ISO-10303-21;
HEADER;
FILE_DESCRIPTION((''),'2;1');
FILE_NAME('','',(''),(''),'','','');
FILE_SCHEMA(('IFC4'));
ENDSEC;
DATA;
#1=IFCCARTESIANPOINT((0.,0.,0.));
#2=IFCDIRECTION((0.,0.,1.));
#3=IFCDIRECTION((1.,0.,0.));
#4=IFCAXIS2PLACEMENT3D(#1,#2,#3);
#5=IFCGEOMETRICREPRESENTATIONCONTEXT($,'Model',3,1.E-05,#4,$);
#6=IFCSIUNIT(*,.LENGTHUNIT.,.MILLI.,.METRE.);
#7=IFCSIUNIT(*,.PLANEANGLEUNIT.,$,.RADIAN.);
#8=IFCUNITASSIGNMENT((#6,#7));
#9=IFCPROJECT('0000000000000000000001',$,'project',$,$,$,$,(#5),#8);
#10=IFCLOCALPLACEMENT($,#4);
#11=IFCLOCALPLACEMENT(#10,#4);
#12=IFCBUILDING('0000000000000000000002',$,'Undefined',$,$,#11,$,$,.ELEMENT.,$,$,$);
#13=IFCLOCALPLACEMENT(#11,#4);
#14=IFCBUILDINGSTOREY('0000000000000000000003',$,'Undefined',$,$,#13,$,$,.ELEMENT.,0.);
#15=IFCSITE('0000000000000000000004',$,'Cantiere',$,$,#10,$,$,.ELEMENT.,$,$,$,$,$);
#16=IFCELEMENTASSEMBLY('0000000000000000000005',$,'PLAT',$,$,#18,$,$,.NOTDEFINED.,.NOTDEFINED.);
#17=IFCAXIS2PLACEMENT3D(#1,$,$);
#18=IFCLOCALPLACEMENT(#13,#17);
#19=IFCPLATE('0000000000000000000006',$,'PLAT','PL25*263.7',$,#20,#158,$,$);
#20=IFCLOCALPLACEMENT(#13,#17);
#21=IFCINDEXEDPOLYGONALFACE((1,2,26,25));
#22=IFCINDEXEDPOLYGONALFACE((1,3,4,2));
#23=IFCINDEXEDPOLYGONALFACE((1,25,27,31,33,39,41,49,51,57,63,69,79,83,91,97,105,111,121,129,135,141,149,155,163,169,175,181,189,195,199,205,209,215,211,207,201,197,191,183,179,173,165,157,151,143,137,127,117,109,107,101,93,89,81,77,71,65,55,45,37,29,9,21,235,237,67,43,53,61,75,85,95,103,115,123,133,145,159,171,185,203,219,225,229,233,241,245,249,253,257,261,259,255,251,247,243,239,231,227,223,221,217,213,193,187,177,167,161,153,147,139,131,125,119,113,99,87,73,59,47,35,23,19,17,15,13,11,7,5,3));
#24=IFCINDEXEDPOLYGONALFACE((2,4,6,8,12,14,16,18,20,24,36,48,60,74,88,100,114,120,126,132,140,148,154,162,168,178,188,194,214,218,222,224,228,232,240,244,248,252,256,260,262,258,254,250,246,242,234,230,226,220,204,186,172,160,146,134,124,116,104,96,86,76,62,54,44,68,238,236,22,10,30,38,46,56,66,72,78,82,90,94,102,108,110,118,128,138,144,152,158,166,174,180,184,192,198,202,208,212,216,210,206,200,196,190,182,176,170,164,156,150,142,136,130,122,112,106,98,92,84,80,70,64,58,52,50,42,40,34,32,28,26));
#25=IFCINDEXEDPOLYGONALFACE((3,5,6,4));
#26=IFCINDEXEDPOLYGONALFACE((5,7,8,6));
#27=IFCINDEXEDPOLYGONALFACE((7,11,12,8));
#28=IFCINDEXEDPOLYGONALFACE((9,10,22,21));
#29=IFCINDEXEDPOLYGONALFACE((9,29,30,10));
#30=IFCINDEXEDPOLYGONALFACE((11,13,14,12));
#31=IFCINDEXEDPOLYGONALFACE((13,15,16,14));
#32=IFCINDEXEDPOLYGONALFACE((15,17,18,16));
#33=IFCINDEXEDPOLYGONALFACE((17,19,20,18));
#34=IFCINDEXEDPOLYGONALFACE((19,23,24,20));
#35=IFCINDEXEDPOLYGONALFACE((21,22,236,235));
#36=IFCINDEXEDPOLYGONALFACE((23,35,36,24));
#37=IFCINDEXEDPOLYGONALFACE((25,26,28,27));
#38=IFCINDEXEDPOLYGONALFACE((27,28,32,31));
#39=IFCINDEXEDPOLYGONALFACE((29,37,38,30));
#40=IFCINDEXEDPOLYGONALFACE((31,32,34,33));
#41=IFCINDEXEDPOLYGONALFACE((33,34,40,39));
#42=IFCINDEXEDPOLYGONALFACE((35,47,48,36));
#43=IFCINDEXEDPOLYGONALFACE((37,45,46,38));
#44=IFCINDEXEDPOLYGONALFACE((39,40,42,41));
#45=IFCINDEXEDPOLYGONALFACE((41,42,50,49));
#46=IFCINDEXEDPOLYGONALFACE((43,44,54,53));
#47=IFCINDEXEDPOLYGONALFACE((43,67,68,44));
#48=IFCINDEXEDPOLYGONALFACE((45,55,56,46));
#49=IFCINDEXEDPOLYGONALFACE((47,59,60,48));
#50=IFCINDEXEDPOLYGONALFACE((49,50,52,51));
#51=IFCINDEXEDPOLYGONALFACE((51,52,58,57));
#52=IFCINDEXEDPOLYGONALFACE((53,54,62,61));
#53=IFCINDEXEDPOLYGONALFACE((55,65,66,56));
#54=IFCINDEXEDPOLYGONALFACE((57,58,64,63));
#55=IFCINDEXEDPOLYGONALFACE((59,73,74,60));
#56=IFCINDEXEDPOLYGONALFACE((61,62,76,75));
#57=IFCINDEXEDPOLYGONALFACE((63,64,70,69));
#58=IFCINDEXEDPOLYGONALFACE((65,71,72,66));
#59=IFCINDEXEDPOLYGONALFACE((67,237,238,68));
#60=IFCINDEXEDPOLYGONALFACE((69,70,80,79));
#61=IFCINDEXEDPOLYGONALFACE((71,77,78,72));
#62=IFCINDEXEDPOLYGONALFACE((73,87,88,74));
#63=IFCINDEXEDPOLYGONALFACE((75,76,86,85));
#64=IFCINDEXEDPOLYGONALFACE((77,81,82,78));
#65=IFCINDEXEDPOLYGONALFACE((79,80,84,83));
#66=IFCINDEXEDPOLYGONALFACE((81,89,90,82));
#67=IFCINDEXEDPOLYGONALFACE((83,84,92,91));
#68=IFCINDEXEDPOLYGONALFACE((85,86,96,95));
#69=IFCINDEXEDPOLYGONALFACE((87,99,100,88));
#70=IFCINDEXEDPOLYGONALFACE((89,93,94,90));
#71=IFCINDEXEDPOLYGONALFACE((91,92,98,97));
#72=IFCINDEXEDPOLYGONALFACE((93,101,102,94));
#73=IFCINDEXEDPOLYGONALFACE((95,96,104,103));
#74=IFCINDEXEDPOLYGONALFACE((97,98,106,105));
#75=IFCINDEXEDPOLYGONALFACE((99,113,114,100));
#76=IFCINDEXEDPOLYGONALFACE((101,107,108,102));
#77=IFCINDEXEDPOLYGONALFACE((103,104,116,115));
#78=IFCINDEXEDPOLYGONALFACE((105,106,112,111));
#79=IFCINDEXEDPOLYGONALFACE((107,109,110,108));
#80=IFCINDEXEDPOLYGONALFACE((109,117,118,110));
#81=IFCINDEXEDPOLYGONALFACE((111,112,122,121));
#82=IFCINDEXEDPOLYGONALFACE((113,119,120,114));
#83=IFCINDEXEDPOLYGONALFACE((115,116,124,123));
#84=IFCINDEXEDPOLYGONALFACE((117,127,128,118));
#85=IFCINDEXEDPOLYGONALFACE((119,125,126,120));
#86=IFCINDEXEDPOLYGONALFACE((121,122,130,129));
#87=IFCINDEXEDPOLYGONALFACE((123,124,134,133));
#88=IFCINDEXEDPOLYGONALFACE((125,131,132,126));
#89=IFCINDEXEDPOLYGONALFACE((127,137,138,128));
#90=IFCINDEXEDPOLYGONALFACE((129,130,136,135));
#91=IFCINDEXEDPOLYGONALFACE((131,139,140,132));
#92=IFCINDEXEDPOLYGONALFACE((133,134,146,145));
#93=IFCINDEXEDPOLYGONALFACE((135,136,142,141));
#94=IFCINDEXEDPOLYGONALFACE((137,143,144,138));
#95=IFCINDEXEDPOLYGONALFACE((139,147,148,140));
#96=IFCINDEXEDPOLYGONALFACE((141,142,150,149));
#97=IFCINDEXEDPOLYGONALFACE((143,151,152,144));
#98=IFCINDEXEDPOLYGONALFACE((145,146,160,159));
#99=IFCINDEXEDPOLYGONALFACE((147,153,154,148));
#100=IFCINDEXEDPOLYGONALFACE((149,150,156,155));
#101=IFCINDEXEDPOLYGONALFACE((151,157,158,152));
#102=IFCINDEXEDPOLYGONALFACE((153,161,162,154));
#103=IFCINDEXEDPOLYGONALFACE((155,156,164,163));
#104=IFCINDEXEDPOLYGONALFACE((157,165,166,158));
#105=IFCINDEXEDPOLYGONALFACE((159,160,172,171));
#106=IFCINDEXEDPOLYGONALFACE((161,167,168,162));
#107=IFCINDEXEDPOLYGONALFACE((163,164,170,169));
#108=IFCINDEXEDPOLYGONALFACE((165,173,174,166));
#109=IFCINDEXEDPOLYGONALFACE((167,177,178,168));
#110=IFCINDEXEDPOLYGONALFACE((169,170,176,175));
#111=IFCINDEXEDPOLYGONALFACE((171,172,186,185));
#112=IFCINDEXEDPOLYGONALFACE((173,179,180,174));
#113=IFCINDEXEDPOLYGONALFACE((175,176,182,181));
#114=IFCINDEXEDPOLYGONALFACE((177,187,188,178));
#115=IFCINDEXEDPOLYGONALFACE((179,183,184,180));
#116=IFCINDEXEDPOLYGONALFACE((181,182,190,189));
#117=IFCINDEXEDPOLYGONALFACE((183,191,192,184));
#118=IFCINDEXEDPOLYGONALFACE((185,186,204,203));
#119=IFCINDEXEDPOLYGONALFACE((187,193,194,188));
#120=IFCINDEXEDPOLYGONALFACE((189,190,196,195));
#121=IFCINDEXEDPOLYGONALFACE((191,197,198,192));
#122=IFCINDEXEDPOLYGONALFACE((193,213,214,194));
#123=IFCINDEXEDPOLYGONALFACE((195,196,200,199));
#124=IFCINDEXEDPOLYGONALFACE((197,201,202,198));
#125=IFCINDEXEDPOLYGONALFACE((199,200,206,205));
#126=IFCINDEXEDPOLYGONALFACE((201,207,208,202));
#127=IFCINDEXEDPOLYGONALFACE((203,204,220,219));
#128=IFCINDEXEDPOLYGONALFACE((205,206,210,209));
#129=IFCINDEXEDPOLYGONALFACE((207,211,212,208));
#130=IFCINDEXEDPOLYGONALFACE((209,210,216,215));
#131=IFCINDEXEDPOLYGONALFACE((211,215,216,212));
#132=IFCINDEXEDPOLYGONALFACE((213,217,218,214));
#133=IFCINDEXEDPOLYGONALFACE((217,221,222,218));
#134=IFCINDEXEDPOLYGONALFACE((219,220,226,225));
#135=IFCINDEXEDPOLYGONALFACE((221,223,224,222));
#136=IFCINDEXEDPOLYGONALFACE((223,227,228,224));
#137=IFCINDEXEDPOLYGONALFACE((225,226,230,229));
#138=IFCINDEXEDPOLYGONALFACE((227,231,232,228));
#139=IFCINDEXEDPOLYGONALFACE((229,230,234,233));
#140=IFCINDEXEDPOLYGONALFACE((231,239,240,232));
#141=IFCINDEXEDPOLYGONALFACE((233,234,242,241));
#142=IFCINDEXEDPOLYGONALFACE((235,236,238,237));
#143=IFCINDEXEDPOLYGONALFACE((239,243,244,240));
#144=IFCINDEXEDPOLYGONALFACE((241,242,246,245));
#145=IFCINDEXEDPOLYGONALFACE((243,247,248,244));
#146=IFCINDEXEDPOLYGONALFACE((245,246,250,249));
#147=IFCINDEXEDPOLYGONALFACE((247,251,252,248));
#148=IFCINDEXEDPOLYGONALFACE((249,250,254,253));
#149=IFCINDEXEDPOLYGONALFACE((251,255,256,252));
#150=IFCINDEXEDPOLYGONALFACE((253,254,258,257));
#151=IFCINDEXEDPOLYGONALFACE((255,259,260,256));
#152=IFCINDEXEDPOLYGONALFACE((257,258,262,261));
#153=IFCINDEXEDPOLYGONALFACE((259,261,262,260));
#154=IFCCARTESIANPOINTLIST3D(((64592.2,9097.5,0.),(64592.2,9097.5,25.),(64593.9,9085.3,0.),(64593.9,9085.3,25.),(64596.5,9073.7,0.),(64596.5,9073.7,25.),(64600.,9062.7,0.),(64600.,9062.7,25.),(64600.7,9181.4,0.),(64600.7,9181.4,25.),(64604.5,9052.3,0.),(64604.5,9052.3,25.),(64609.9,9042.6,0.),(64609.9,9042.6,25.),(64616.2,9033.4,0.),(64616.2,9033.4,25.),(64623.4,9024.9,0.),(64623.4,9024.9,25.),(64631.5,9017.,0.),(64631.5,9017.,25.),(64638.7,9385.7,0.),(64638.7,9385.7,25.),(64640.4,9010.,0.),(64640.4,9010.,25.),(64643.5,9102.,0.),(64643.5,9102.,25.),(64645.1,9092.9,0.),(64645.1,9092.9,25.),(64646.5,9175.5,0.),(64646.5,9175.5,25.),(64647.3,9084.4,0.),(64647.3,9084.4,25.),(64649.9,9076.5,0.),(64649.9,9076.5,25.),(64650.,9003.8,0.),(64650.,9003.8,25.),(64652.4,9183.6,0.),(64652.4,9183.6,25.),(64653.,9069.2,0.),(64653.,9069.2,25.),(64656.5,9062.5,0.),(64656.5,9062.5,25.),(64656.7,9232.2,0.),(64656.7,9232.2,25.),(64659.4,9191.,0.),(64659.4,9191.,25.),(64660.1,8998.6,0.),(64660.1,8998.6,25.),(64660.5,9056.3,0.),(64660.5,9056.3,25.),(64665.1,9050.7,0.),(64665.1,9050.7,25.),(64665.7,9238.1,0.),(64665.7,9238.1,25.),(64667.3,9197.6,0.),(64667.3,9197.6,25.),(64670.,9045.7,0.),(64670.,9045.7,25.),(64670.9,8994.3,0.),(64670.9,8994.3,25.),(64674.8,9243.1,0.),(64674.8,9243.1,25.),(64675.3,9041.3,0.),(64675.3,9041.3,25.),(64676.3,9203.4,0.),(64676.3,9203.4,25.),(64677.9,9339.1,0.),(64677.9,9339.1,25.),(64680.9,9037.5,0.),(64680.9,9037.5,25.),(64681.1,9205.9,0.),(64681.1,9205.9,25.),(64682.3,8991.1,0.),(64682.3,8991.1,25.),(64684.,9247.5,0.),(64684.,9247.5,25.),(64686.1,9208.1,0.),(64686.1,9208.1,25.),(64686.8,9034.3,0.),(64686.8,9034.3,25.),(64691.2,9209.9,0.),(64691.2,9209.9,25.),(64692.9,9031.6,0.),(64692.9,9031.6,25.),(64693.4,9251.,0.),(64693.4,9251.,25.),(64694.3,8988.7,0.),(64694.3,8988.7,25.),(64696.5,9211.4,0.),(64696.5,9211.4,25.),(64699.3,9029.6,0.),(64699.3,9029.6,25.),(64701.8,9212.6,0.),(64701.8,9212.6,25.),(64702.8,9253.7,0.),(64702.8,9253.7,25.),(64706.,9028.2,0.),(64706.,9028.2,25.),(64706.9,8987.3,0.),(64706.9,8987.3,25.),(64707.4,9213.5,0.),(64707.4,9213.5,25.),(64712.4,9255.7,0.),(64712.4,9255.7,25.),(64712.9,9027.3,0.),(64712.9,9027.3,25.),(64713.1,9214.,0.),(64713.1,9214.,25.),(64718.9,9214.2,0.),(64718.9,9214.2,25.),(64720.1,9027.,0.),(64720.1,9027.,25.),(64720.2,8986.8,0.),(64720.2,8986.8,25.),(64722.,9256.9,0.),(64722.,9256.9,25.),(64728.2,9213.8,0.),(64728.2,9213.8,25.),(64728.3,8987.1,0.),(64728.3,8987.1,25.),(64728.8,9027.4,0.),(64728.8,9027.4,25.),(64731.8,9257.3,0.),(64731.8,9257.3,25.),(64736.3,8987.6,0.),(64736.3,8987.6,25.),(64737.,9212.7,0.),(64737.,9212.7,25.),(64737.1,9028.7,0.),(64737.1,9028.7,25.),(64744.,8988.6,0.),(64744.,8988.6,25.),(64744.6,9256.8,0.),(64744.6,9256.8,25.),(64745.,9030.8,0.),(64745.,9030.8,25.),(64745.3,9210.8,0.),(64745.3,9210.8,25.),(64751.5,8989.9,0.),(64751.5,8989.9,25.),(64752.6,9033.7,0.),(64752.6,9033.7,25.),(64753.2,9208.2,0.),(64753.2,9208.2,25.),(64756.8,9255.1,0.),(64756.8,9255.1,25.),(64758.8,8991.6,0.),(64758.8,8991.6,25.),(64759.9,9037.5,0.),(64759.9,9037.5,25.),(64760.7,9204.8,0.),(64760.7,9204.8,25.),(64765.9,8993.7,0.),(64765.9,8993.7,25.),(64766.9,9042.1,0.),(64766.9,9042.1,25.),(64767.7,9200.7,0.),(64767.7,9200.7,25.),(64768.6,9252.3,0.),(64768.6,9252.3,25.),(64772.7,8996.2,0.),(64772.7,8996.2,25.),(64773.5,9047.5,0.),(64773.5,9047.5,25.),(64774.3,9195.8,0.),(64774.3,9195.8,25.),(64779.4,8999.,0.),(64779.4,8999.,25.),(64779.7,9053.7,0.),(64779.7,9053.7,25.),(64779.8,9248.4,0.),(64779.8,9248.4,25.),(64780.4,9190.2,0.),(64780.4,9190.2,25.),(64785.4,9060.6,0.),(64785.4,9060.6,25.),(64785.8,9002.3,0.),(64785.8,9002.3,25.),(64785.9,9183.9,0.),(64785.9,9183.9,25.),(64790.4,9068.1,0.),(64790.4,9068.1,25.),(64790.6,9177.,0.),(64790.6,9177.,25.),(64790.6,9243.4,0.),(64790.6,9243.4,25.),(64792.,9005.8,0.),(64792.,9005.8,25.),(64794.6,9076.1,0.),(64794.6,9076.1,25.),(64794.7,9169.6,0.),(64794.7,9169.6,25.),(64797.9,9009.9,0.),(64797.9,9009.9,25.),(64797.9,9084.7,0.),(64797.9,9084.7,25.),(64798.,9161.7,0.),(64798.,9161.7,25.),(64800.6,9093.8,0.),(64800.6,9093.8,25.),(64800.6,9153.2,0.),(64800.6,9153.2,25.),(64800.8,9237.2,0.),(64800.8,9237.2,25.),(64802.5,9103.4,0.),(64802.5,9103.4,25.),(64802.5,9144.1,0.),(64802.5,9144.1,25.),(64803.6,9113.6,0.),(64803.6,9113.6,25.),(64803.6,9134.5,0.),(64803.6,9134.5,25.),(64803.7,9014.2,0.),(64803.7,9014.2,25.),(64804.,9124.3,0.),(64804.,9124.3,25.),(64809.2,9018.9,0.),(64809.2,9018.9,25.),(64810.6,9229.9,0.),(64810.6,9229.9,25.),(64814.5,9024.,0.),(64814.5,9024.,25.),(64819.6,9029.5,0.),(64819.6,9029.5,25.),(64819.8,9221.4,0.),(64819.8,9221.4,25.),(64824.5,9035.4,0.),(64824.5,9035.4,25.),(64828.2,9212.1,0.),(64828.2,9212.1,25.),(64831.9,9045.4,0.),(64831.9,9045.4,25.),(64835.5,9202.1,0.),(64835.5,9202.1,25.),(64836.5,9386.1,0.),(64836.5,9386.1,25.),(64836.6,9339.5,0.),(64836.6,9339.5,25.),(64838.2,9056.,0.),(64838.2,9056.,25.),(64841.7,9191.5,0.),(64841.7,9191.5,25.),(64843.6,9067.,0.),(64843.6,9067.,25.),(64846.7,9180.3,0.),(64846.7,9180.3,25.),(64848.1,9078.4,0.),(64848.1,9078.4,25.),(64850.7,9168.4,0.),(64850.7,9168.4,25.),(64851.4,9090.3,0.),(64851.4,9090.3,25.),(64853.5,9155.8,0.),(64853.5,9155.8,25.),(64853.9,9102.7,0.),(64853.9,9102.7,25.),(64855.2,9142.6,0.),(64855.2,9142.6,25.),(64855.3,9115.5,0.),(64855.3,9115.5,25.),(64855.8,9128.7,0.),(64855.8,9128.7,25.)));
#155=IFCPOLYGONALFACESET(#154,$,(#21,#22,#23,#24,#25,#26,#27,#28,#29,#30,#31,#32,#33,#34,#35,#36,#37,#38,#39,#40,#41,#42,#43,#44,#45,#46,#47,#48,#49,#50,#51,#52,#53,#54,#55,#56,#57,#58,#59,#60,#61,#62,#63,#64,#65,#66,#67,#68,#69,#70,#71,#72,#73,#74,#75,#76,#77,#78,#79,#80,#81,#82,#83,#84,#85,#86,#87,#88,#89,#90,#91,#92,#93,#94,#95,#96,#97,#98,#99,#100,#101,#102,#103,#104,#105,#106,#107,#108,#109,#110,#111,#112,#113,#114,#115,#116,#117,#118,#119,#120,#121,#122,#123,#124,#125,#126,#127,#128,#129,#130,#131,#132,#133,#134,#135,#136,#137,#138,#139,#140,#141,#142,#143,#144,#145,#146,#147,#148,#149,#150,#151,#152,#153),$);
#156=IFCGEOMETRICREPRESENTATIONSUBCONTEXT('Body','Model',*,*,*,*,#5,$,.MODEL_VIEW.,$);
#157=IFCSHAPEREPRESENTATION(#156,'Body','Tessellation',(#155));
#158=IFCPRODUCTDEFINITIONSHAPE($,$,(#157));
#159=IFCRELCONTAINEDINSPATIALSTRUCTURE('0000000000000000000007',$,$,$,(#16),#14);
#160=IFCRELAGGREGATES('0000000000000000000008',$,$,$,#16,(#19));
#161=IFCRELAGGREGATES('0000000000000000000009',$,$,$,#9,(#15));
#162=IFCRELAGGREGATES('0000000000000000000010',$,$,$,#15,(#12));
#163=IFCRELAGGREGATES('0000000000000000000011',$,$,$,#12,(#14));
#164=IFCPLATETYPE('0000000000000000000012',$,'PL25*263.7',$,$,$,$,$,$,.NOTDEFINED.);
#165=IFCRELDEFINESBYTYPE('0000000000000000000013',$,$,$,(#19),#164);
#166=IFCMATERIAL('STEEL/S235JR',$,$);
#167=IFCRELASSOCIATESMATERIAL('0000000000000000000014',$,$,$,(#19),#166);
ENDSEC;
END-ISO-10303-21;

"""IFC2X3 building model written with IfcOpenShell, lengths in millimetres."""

from ifc_helpers import new_model, si_unit, frame, origin_with_axes, place, context, subcontext, project, spatial, polyline, outline, extrude, material, type_object, element, aggregate, save


model = new_model("IFC2X3")

# Units and contexts
model_context = context("Model", 3, precision=1e-05, world=origin_with_axes())
body_context = subcontext(model_context, "Body", "Model", "MODEL_VIEW")
ifc_project = project(units=[si_unit("LENGTHUNIT", "METRE", prefix="MILLI"), si_unit("PLANEANGLEUNIT", "RADIAN")], contexts=[model_context])

# Site, building, storey
site_placement = place(None, origin_with_axes())
site = spatial("IfcSite", under=ifc_project, at=site_placement, Name="Cantiere", CompositionType="ELEMENT")
building_placement = place(site_placement, origin_with_axes())
building = spatial("IfcBuilding", under=site, at=building_placement, Name="Undefined", CompositionType="ELEMENT")
storey_placement = place(building_placement, origin_with_axes())
storey = spatial("IfcBuildingStorey", under=building, at=storey_placement, Name="Undefined", CompositionType="ELEMENT", Elevation=0.0)

# Shared definitions
ifc_material_1 = material(Name="STEEL/S235JR")

# Element assembly, plate
assembly_1_placement = place(storey_placement, origin_with_axes())
assembly_1 = element("IfcElementAssembly", 1, at=assembly_1_placement, inside=storey, Name="PLAT", AssemblyPlace="NOTDEFINED", PredefinedType="NOTDEFINED")
plate_type_1 = type_object("IfcPlateType", Name="PL25*263.7", PredefinedType="NOTDEFINED")
plate_1_placement = place(assembly_1_placement, frame((64592.2, 9097.5, 12.5), z_axis=(0.0, 0.000001, -1.0), x_axis=(0.996243, 0.086604, 0.0)))
plate_1 = element("IfcPlate", 2, at=plate_1_placement, type_object=plate_type_1, material=ifc_material_1, Name="PLAT", Description="PL25*263.7", context=body_context, shape_type="SweptSolid", body=[
    extrude(outline(polyline([(0.0, 0.0), (51.5, 0.0), (52.4, 9.2), (53.8, 17.8), (55.7, 25.9), (58.1, 33.5), (61.1, 40.5), (64.6, 47.0), (68.6, 52.9), (73.1, 58.3), (78.0, 63.2), (83.2, 67.5), (88.8, 71.2), (94.7, 74.4), (100.9, 76.9), (107.4, 79.0), (114.2, 80.4), (121.4, 81.3), (130.0, 81.7), (138.4, 81.1), (146.5, 79.7), (154.4, 77.5), (161.9, 74.3), (169.3, 70.4), (176.3, 65.5), (183.0, 59.9), (189.4, 53.5), (194.9, 46.5), (199.8, 38.8), (203.9, 30.6), (207.3, 21.8), (210.1, 12.3), (212.0, 2.3), (213.3, -8.4), (213.8, -18.5), (213.5, -28.2), (212.5, -37.4), (210.6, -46.1), (208.0, -54.3), (204.6, -62.0), (200.5, -69.3), (195.5, -76.0), (189.9, -82.1), (183.8, -87.6), (177.2, -92.3), (170.0, -96.3), (162.4, -99.6), (154.2, -102.2), (145.6, -104.1), (136.3, -105.3), (130.5, -105.6), (124.8, -105.6), (119.2, -105.2), (113.8, -104.5), (108.4, -103.4), (103.2, -102.0), (98.0, -100.3), (93.0, -98.2), (83.6, -93.2), (75.0, -87.3), (67.5, -80.6), (60.9, -73.0), (15.8, -82.8), (71.4, -283.1), (268.4, -266.4), (264.5, -219.9), (106.4, -233.3), (76.0, -128.6), (85.4, -133.7), (94.9, -137.9), (104.5, -141.4), (114.1, -144.1), (123.8, -146.1), (133.5, -147.2), (143.2, -147.5), (153.0, -147.1), (165.6, -145.5), (177.7, -142.7), (189.2, -139.0), (200.0, -134.1), (210.3, -128.1), (220.0, -121.1), (229.1, -112.9), (237.5, -103.8), (245.1, -93.7), (251.5, -83.1), (256.7, -72.1), (260.8, -60.4), (263.7, -48.2), (265.4, -35.4), (266.0, -22.1), (265.3, -8.3), (263.7, 4.9), (261.2, 17.5), (257.7, 29.6), (253.3, 41.2), (247.9, 52.2), (241.6, 62.7), (234.3, 72.7), (226.1, 82.0), (220.7, 87.5), (215.2, 92.5), (209.4, 97.1), (203.5, 101.4), (197.4, 105.2), (191.1, 108.6), (184.6, 111.6), (178.0, 114.3), (171.1, 116.6), (164.1, 118.4), (156.8, 119.9), (149.5, 121.0), (141.9, 121.7), (134.1, 122.0), (126.1, 121.8), (118.0, 121.4), (104.8, 119.7), (92.3, 117.3), (80.6, 113.9), (69.5, 109.6), (59.1, 104.4), (49.5, 98.4), (40.5, 91.4), (32.3, 83.6), (24.9, 75.0), (18.4, 65.9), (12.9, 56.3), (8.4, 46.1), (4.8, 35.4), (2.3, 24.1), (0.7, 12.3), (0.0, 0.0)])), frame((0.0, 0.0, -12.5), z_axis=(0.0, 0.0, 1.0), x_axis=(1.0, 0.0, 0.0)), (0.0, 0.0, 1.0), 25.0),
])
aggregate(assembly_1, [plate_1])

save(model, "model.ifc")
